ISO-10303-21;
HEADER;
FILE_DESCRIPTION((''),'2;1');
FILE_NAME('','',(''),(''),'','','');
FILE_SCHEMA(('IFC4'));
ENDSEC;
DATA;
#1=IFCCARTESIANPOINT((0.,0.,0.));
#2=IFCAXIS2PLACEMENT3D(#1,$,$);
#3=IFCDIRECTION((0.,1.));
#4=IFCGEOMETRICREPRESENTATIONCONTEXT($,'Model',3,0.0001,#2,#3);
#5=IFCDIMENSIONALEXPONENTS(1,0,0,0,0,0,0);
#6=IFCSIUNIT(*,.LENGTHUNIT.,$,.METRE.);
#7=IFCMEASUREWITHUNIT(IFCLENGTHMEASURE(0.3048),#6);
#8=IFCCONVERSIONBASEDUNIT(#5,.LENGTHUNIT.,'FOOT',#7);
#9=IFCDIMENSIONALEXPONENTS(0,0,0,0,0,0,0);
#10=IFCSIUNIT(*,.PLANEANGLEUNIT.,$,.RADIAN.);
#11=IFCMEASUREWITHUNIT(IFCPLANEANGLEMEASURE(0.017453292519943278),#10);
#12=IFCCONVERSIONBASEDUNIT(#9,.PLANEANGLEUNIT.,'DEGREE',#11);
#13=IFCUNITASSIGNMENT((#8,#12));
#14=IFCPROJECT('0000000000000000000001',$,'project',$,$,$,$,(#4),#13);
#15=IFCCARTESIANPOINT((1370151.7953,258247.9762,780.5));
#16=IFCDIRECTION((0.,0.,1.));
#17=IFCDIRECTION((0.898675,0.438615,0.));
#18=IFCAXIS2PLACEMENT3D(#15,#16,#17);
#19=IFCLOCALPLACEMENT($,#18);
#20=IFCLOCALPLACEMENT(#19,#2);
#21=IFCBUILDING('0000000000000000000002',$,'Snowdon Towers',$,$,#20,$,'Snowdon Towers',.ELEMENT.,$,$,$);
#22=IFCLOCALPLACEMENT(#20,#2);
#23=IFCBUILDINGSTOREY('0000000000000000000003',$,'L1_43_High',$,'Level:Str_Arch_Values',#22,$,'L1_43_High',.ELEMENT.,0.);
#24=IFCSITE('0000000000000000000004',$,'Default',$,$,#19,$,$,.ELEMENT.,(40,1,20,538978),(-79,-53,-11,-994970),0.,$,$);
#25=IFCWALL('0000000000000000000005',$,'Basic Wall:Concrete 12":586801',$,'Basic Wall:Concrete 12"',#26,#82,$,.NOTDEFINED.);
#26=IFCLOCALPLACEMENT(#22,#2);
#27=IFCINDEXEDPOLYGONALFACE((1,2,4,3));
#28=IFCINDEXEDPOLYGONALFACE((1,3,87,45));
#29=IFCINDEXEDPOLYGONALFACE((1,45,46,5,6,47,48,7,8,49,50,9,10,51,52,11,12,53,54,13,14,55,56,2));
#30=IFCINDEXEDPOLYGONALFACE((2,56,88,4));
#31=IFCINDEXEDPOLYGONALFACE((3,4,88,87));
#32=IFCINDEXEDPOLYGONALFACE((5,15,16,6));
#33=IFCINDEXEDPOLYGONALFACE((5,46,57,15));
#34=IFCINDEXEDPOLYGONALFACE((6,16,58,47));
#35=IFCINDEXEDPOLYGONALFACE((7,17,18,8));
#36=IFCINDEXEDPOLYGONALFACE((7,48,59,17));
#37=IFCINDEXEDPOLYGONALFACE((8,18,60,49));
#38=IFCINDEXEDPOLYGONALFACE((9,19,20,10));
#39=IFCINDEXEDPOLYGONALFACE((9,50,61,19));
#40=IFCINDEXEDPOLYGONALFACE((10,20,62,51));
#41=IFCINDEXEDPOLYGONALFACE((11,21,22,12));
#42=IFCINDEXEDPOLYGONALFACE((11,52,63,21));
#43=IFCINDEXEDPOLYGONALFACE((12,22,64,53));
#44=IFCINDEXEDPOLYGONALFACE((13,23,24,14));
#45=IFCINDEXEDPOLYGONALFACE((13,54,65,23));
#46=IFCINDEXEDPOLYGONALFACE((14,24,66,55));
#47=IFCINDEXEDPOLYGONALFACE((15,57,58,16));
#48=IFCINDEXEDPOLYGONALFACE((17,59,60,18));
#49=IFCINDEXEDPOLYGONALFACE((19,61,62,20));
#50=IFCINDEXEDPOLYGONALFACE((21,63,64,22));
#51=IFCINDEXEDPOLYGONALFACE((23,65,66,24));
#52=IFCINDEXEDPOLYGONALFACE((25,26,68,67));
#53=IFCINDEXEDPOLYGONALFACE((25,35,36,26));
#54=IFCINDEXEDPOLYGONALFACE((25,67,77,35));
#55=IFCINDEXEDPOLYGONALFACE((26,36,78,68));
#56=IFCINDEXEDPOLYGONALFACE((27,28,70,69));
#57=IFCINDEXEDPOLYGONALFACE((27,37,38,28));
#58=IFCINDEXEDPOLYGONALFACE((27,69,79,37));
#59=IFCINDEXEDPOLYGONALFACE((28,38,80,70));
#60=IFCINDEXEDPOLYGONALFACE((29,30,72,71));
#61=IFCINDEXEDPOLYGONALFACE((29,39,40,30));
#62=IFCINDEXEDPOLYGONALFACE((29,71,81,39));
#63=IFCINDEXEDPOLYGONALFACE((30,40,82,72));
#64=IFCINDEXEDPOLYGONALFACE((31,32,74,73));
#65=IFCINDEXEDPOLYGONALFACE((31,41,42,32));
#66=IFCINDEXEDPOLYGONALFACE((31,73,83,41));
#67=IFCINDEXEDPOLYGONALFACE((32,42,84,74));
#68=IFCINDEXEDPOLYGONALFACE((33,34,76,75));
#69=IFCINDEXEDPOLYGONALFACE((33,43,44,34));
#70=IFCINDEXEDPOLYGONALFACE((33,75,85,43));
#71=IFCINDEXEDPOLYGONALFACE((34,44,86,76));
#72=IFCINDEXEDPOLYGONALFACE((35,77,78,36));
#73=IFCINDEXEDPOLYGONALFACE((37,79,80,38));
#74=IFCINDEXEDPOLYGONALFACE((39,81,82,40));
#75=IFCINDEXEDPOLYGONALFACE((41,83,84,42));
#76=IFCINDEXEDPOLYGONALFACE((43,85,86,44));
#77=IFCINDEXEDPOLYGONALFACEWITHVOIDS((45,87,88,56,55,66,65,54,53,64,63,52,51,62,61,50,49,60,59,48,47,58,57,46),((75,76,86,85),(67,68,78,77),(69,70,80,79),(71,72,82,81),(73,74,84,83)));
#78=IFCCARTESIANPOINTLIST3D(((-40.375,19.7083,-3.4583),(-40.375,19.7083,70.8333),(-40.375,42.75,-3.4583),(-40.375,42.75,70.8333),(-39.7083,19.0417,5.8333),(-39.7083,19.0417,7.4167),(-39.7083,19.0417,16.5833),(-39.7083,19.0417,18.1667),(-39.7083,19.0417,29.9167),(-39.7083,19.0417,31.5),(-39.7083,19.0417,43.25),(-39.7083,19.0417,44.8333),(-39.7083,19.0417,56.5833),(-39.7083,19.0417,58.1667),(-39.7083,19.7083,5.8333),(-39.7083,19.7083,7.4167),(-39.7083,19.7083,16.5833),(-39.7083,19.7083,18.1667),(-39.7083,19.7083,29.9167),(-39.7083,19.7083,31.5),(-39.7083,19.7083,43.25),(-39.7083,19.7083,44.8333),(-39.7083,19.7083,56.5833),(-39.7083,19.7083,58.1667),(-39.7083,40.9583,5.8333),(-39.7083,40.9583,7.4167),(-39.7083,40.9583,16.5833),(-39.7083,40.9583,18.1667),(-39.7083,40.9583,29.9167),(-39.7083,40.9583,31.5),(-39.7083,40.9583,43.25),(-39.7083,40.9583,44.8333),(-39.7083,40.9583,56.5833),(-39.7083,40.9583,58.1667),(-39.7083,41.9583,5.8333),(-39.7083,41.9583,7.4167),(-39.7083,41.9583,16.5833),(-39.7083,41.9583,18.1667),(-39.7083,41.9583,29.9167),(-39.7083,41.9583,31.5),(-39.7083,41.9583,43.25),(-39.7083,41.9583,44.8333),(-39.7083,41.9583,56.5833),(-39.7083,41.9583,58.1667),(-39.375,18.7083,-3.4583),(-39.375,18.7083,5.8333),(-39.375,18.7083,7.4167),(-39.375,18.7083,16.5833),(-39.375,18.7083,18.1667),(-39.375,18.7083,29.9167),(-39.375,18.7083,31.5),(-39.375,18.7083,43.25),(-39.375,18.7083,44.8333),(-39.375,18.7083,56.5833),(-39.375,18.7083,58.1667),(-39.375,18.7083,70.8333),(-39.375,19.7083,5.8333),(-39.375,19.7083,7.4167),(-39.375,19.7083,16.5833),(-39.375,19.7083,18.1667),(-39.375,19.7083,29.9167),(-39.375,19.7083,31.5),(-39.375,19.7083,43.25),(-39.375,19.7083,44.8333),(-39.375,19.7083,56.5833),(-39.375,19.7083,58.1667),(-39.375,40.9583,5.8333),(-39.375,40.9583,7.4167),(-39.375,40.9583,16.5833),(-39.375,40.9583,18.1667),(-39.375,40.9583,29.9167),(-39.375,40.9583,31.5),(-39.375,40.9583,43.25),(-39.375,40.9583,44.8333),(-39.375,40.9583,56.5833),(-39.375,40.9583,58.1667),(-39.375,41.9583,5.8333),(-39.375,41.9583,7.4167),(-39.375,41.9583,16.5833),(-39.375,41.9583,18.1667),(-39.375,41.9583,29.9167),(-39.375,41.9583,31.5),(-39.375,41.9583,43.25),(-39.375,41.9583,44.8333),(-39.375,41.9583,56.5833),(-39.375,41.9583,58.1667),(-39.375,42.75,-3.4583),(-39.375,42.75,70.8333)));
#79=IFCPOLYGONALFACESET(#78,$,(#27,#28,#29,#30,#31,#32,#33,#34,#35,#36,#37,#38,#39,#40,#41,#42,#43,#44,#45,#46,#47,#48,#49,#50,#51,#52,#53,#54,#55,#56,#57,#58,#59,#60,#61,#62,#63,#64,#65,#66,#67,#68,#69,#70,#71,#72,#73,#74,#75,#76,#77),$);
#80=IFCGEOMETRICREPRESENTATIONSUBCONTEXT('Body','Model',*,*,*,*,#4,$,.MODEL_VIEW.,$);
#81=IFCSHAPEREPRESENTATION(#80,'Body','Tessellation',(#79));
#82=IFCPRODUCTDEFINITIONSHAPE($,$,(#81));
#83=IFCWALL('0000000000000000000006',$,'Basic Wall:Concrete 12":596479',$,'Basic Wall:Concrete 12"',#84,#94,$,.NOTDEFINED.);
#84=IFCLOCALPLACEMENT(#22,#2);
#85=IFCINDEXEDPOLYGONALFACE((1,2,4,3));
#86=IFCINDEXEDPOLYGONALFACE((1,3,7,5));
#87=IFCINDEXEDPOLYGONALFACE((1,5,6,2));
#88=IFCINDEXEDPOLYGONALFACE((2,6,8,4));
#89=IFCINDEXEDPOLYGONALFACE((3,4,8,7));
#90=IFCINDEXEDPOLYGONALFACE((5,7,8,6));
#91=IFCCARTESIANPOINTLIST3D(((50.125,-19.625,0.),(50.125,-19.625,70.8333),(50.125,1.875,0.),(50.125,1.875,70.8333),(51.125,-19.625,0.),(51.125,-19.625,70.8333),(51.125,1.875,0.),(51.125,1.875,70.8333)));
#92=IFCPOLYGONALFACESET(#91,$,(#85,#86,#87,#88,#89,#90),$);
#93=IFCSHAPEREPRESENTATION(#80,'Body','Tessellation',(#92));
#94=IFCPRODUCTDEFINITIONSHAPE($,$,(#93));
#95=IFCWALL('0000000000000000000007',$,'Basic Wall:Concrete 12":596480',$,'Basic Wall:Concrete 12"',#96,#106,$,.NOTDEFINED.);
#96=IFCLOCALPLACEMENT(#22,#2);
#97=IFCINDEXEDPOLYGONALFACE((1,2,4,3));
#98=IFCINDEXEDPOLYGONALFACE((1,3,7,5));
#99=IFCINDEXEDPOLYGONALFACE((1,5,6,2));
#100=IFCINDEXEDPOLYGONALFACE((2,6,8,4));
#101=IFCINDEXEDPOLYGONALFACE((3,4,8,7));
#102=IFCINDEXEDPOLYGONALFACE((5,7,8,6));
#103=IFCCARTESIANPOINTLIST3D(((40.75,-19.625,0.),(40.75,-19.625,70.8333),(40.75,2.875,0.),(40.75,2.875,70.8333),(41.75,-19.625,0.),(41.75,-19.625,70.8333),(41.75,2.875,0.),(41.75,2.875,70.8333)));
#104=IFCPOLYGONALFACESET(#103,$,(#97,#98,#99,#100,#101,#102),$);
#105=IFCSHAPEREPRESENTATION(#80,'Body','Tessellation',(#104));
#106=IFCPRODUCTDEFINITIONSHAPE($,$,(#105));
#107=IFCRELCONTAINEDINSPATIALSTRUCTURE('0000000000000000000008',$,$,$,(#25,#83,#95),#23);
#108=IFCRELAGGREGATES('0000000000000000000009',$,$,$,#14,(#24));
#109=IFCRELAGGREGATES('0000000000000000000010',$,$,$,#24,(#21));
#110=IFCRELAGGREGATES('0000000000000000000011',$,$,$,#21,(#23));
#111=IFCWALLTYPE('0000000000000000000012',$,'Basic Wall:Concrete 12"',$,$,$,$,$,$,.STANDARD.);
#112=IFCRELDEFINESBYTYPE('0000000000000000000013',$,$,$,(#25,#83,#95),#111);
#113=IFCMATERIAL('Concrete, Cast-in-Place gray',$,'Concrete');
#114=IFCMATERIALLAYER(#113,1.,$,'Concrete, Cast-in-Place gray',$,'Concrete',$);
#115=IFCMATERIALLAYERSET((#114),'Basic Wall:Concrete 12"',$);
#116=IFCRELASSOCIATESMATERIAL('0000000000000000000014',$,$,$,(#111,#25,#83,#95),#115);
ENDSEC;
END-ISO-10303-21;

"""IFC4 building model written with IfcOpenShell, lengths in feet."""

from ifc_helpers import new_model, entity, si_unit, converted_unit, direction, frame, frame_2d, origin, origin_2d_with_axis, place, context, subcontext, project, spatial, polyline, rectangle, outline, extrude, material, layer, layer_set, layer_usage, type_object, element, save


model = new_model("IFC4")

# Units and contexts
model_context = context("Model", 3, precision=0.0001, world=origin(), true_north=direction((0.0, 1.0)))
body_context = subcontext(model_context, "Body", "Model", "MODEL_VIEW")
ifc_project = project(units=[converted_unit("LENGTHUNIT", "FOOT", entity("IfcLengthMeasure", 0.3048), si_unit("LENGTHUNIT", "METRE"), dimensions=[1, 0, 0, 0, 0, 0, 0]), converted_unit("PLANEANGLEUNIT", "DEGREE", entity("IfcPlaneAngleMeasure", 0.017453292519943278), si_unit("PLANEANGLEUNIT", "RADIAN"), dimensions=[0, 0, 0, 0, 0, 0, 0])], contexts=[model_context])

# Site, building, storey
site_placement = place(None, frame((1370151.7953, 258247.9762, 780.5), z_axis=(0.0, 0.0, 1.0), x_axis=(0.898675, 0.438615, 0.0)))
site = spatial("IfcSite", under=ifc_project, at=site_placement, Name="Default", CompositionType="ELEMENT", RefLatitude=(40, 1, 20, 538978), RefLongitude=(-79, -53, -11, -994970), RefElevation=0.0)
building_placement = place(site_placement, origin())
building = spatial("IfcBuilding", under=site, at=building_placement, Name="Snowdon Towers", LongName="Snowdon Towers", CompositionType="ELEMENT")
storey_placement = place(building_placement, origin())
storey = spatial("IfcBuildingStorey", under=building, at=storey_placement, Name="L1_43_High", ObjectType="Level:Str_Arch_Values", LongName="L1_43_High", CompositionType="ELEMENT", Elevation=0.0)

# Wall, openings
ifc_material = material(Name="Concrete, Cast-in-Place gray", Category="Concrete")
ifc_layer = layer(ifc_material, 1.0, Name="Concrete, Cast-in-Place gray", Category="Concrete")
ifc_layer_set = layer_set([ifc_layer], Name="Basic Wall:Concrete 12\"")
ifc_layer_usage_1 = layer_usage(ifc_layer_set, "AXIS2", "NEGATIVE", 0.5)
wall_type = type_object("IfcWallType", Name="Basic Wall:Concrete 12\"", PredefinedType="STANDARD", material=ifc_layer_set)
wall_1_placement = place(storey_placement, frame((-39.875, 18.7083, -3.4583), z_axis=(0.0, 0.0, 1.0), x_axis=(0.0, 1.0, 0.0)))
wall_1 = element("IfcWall", 1, at=wall_1_placement, inside=storey, type_object=wall_type, material=ifc_layer_usage_1, Name="Basic Wall:Concrete 12\":586801", ObjectType="Basic Wall:Concrete 12\"", PredefinedType="NOTDEFINED", context=body_context, shape_type="SweptSolid", body=[
    extrude(outline(polyline([(24.0417, -0.5), (24.0417, 0.5), (1.0, 0.5), (0.0, -0.5), (24.0417, -0.5)])), origin(), (0.0, 0.0, 1.0), 74.2917),
])
opening_1_placement = place(wall_1_placement, origin())
element("IfcOpeningElement", 2, at=opening_1_placement, cuts=wall_1, PredefinedType="RECESS", context=body_context, shape_type="SweptSolid", body=[
    extrude(rectangle(XDim=1.5833, YDim=1.0, at=origin_2d_with_axis()), frame((0.5, -0.5, 10.0833), z_axis=(0.0, 1.0, 0.0), x_axis=(0.0, 0.0, -1.0)), (0.0, 0.0, 1.0), 0.3333),
])
opening_2_placement = place(wall_1_placement, origin())
element("IfcOpeningElement", 3, at=opening_2_placement, cuts=wall_1, PredefinedType="RECESS", context=body_context, shape_type="SweptSolid", body=[
    extrude(rectangle(XDim=1.5833, YDim=1.0, at=frame_2d((0.0, 0.0), x_axis=(1.0, 0.0))), frame((0.5, -0.5, 20.8333), z_axis=(0.0, 1.0, 0.0), x_axis=(0.0, 0.0, -1.0)), (0.0, 0.0, 1.0), 0.3333),
])
opening_3_placement = place(wall_1_placement, origin())
element("IfcOpeningElement", 4, at=opening_3_placement, cuts=wall_1, PredefinedType="RECESS", context=body_context, shape_type="SweptSolid", body=[
    extrude(rectangle(XDim=1.5833, YDim=1.0, at=frame_2d((0.0, 0.0), x_axis=(1.0, 0.0))), frame((0.5, -0.5, 34.1667), z_axis=(0.0, 1.0, 0.0), x_axis=(0.0, 0.0, -1.0)), (0.0, 0.0, 1.0), 0.3333),
])
opening_4_placement = place(wall_1_placement, origin())
element("IfcOpeningElement", 5, at=opening_4_placement, cuts=wall_1, PredefinedType="RECESS", context=body_context, shape_type="SweptSolid", body=[
    extrude(rectangle(XDim=1.5833, YDim=1.0, at=origin_2d_with_axis()), frame((0.5, -0.5, 47.5), z_axis=(0.0, 1.0, 0.0), x_axis=(0.0, 0.0, -1.0)), (0.0, 0.0, 1.0), 0.3333),
])
opening_5_placement = place(wall_1_placement, origin())
element("IfcOpeningElement", 6, at=opening_5_placement, cuts=wall_1, PredefinedType="RECESS", context=body_context, shape_type="SweptSolid", body=[
    extrude(rectangle(XDim=1.5833, YDim=1.0, at=frame_2d((0.0, 0.0), x_axis=(1.0, 0.0))), frame((0.5, -0.5, 60.8333), z_axis=(0.0, 1.0, 0.0), x_axis=(0.0, 0.0, -1.0)), (0.0, 0.0, 1.0), 0.3333),
])
opening_6_placement = place(wall_1_placement, origin())
element("IfcOpeningElement", 7, at=opening_6_placement, cuts=wall_1, PredefinedType="RECESS", context=body_context, shape_type="SweptSolid", body=[
    extrude(rectangle(XDim=1.5833, YDim=1.0, at=frame_2d((0.0, 0.0), x_axis=(1.0, 0.0))), frame((22.75, -0.5, 20.8333), z_axis=(0.0, 1.0, 0.0), x_axis=(0.0, 0.0, -1.0)), (0.0, 0.0, 1.0), 0.3333),
])
opening_7_placement = place(wall_1_placement, origin())
element("IfcOpeningElement", 8, at=opening_7_placement, cuts=wall_1, PredefinedType="RECESS", context=body_context, shape_type="SweptSolid", body=[
    extrude(rectangle(XDim=1.5833, YDim=1.0, at=frame_2d((0.0, 0.0), x_axis=(1.0, 0.0))), frame((22.75, -0.5, 10.0833), z_axis=(0.0, 1.0, 0.0), x_axis=(0.0, 0.0, -1.0)), (0.0, 0.0, 1.0), 0.3333),
])
opening_8_placement = place(wall_1_placement, origin())
element("IfcOpeningElement", 9, at=opening_8_placement, cuts=wall_1, PredefinedType="RECESS", context=body_context, shape_type="SweptSolid", body=[
    extrude(rectangle(XDim=1.5833, YDim=1.0, at=frame_2d((0.0, 0.0), x_axis=(1.0, 0.0))), frame((22.75, -0.5, 34.1667), z_axis=(0.0, 1.0, 0.0), x_axis=(0.0, 0.0, -1.0)), (0.0, 0.0, 1.0), 0.3333),
])
opening_9_placement = place(wall_1_placement, origin())
element("IfcOpeningElement", 10, at=opening_9_placement, cuts=wall_1, PredefinedType="RECESS", context=body_context, shape_type="SweptSolid", body=[
    extrude(rectangle(XDim=1.5833, YDim=1.0, at=origin_2d_with_axis()), frame((22.75, -0.5, 47.5), z_axis=(0.0, 1.0, 0.0), x_axis=(0.0, 0.0, -1.0)), (0.0, 0.0, 1.0), 0.3333),
])
opening_10_placement = place(wall_1_placement, origin())
element("IfcOpeningElement", 11, at=opening_10_placement, cuts=wall_1, PredefinedType="RECESS", context=body_context, shape_type="SweptSolid", body=[
    extrude(rectangle(XDim=1.5833, YDim=1.0, at=frame_2d((0.0, 0.0), x_axis=(1.0, 0.0))), frame((22.75, -0.5, 60.8333), z_axis=(0.0, 1.0, 0.0), x_axis=(0.0, 0.0, -1.0)), (0.0, 0.0, 1.0), 0.3333),
])

# Walls
ifc_layer_usage_2 = layer_usage(ifc_layer_set, "AXIS2", "NEGATIVE", 0.5)
wall_2_placement = place(storey_placement, frame((50.625, -19.625, 0.0), z_axis=(0.0, 0.0, 1.0), x_axis=(0.0, 1.0, 0.0)))
element("IfcWall", 12, at=wall_2_placement, inside=storey, type_object=wall_type, material=ifc_layer_usage_2, Name="Basic Wall:Concrete 12\":596479", ObjectType="Basic Wall:Concrete 12\"", PredefinedType="NOTDEFINED", context=body_context, shape_type="SweptSolid", body=[
    extrude(rectangle(XDim=21.5, YDim=1.0, at=frame_2d((10.75, 0.0), x_axis=(-1.0, 0.0))), origin(), (0.0, 0.0, 1.0), 70.8333),
])
ifc_layer_usage_3 = layer_usage(ifc_layer_set, "AXIS2", "POSITIVE", -0.5)
wall_3_placement = place(storey_placement, frame((41.25, 2.875, 0.0), z_axis=(0.0, 0.0, 1.0), x_axis=(0.0, -1.0, 0.0)))
element("IfcWall", 13, at=wall_3_placement, inside=storey, type_object=wall_type, material=ifc_layer_usage_3, Name="Basic Wall:Concrete 12\":596480", ObjectType="Basic Wall:Concrete 12\"", PredefinedType="NOTDEFINED", context=body_context, shape_type="SweptSolid", body=[
    extrude(rectangle(XDim=22.5, YDim=1.0, at=frame_2d((11.25, 0.0), x_axis=(-1.0, 0.0))), origin(), (0.0, 0.0, 1.0), 70.8333),
])

save(model, "model.ifc")
